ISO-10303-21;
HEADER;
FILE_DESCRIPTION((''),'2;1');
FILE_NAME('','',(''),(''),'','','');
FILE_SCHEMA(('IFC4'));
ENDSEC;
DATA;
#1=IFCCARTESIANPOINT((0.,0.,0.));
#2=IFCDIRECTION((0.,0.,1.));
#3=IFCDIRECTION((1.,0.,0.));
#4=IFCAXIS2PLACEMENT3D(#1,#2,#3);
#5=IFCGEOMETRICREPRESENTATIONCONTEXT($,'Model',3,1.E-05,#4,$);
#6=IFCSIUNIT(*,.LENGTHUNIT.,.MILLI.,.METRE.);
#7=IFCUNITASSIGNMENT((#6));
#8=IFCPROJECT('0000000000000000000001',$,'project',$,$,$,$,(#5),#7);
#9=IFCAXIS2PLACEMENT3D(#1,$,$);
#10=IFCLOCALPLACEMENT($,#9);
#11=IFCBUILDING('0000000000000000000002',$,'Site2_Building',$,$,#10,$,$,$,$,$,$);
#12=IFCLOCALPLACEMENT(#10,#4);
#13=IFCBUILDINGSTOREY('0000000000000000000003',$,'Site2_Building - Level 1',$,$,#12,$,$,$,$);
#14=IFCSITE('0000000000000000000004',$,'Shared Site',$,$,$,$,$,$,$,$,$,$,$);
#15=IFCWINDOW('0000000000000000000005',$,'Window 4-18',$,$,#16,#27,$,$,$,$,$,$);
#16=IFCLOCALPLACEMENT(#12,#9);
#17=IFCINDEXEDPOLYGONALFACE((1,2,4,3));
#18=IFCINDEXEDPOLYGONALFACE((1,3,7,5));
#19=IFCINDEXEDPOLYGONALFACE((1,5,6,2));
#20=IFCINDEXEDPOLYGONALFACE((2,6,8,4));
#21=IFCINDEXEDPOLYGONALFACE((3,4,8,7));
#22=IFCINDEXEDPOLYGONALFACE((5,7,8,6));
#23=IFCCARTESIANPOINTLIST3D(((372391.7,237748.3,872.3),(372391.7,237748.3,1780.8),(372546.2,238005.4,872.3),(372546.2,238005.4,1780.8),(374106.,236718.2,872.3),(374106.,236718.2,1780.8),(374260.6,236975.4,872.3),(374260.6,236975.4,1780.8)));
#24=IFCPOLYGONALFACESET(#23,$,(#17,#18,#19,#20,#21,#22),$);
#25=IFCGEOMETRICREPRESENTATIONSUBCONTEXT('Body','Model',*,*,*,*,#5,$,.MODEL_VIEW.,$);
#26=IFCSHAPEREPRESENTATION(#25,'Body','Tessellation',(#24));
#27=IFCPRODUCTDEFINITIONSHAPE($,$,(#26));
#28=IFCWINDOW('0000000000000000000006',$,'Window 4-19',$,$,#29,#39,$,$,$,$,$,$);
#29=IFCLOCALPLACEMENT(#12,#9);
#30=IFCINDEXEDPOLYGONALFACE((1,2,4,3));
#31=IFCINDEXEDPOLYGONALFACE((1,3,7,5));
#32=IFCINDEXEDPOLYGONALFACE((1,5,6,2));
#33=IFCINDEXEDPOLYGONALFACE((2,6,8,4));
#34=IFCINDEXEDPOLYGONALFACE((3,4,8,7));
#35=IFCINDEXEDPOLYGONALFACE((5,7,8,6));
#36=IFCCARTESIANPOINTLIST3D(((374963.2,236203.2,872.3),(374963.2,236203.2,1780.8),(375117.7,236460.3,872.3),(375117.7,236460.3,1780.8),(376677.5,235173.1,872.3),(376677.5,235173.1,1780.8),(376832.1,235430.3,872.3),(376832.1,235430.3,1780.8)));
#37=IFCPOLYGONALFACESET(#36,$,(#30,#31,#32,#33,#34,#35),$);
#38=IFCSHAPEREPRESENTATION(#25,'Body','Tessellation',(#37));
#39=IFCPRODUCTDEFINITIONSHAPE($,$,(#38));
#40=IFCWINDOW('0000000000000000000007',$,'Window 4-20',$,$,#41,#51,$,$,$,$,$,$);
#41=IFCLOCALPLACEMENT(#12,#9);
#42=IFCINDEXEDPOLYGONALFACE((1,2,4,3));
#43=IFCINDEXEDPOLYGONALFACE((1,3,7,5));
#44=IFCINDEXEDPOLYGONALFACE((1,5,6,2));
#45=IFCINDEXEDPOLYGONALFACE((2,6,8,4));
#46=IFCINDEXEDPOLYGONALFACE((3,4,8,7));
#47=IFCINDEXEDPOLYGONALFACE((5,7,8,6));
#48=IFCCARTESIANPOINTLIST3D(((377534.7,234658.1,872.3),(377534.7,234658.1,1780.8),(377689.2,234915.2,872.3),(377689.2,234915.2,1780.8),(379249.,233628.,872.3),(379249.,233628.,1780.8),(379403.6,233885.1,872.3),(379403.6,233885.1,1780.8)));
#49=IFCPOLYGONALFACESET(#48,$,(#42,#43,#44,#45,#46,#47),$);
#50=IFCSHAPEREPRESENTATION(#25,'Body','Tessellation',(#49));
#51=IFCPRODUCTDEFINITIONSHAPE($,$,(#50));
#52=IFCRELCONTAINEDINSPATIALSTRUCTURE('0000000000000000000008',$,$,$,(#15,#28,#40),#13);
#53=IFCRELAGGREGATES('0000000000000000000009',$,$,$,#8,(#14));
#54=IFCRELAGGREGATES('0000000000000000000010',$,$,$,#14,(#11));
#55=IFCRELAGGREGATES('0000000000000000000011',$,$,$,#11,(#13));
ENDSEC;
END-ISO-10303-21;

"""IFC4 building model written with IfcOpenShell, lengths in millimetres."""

from ifc_helpers import new_model, si_unit, frame, origin, origin_with_axes, place, context, subcontext, project, spatial, indexed_curve, outline, extrude, element, save


model = new_model("IFC4")

# Units and contexts
model_context = context("Model", 3, precision=1e-05, world=origin_with_axes())
body_context = subcontext(model_context, "Body", "Model", "MODEL_VIEW")
ifc_project = project(units=[si_unit("LENGTHUNIT", "METRE", prefix="MILLI")], contexts=[model_context])

# Site, building, storey
site = spatial("IfcSite", under=ifc_project, Name="Shared Site")
building_placement = place(None, origin())
building = spatial("IfcBuilding", under=site, at=building_placement, Name="Site2_Building")
storey_placement = place(building_placement, origin_with_axes())
storey = spatial("IfcBuildingStorey", under=building, at=storey_placement, Name="Site2_Building - Level 1")

# Windows
for number, where, z_axis, x_axis, name in (
    (1, (372391.7, 237748.3, 872.3), (0.0, 0.0, 1.0), (0.857167, -0.515038, 0.0), "Window 4-18"),
    (2, (374963.2, 236203.2, 872.3), (0.0, 0.0, 1.0), (0.857167, -0.515038, 0.0), "Window 4-19"),
    (3, (377534.7, 234658.1, 872.3), (0.0, 0.0, 1.0), (0.857167, -0.515038, 0.0), "Window 4-20"),
):
    element("IfcWindow", number, at=place(storey_placement, frame(where, z_axis=z_axis, x_axis=x_axis)), inside=storey, Name=name, context=body_context, shape_type="SweptSolid", body=[
        extrude(outline(indexed_curve([(0.0, 0.0), (0.0, 300.0), (2000.0, 300.0), (2000.0, 0.0), (0.0, 0.0)], self_intersect=False)), origin_with_axes(), (0.0, 0.0, 1.0), 908.6),
    ])

save(model, "model.ifc")
